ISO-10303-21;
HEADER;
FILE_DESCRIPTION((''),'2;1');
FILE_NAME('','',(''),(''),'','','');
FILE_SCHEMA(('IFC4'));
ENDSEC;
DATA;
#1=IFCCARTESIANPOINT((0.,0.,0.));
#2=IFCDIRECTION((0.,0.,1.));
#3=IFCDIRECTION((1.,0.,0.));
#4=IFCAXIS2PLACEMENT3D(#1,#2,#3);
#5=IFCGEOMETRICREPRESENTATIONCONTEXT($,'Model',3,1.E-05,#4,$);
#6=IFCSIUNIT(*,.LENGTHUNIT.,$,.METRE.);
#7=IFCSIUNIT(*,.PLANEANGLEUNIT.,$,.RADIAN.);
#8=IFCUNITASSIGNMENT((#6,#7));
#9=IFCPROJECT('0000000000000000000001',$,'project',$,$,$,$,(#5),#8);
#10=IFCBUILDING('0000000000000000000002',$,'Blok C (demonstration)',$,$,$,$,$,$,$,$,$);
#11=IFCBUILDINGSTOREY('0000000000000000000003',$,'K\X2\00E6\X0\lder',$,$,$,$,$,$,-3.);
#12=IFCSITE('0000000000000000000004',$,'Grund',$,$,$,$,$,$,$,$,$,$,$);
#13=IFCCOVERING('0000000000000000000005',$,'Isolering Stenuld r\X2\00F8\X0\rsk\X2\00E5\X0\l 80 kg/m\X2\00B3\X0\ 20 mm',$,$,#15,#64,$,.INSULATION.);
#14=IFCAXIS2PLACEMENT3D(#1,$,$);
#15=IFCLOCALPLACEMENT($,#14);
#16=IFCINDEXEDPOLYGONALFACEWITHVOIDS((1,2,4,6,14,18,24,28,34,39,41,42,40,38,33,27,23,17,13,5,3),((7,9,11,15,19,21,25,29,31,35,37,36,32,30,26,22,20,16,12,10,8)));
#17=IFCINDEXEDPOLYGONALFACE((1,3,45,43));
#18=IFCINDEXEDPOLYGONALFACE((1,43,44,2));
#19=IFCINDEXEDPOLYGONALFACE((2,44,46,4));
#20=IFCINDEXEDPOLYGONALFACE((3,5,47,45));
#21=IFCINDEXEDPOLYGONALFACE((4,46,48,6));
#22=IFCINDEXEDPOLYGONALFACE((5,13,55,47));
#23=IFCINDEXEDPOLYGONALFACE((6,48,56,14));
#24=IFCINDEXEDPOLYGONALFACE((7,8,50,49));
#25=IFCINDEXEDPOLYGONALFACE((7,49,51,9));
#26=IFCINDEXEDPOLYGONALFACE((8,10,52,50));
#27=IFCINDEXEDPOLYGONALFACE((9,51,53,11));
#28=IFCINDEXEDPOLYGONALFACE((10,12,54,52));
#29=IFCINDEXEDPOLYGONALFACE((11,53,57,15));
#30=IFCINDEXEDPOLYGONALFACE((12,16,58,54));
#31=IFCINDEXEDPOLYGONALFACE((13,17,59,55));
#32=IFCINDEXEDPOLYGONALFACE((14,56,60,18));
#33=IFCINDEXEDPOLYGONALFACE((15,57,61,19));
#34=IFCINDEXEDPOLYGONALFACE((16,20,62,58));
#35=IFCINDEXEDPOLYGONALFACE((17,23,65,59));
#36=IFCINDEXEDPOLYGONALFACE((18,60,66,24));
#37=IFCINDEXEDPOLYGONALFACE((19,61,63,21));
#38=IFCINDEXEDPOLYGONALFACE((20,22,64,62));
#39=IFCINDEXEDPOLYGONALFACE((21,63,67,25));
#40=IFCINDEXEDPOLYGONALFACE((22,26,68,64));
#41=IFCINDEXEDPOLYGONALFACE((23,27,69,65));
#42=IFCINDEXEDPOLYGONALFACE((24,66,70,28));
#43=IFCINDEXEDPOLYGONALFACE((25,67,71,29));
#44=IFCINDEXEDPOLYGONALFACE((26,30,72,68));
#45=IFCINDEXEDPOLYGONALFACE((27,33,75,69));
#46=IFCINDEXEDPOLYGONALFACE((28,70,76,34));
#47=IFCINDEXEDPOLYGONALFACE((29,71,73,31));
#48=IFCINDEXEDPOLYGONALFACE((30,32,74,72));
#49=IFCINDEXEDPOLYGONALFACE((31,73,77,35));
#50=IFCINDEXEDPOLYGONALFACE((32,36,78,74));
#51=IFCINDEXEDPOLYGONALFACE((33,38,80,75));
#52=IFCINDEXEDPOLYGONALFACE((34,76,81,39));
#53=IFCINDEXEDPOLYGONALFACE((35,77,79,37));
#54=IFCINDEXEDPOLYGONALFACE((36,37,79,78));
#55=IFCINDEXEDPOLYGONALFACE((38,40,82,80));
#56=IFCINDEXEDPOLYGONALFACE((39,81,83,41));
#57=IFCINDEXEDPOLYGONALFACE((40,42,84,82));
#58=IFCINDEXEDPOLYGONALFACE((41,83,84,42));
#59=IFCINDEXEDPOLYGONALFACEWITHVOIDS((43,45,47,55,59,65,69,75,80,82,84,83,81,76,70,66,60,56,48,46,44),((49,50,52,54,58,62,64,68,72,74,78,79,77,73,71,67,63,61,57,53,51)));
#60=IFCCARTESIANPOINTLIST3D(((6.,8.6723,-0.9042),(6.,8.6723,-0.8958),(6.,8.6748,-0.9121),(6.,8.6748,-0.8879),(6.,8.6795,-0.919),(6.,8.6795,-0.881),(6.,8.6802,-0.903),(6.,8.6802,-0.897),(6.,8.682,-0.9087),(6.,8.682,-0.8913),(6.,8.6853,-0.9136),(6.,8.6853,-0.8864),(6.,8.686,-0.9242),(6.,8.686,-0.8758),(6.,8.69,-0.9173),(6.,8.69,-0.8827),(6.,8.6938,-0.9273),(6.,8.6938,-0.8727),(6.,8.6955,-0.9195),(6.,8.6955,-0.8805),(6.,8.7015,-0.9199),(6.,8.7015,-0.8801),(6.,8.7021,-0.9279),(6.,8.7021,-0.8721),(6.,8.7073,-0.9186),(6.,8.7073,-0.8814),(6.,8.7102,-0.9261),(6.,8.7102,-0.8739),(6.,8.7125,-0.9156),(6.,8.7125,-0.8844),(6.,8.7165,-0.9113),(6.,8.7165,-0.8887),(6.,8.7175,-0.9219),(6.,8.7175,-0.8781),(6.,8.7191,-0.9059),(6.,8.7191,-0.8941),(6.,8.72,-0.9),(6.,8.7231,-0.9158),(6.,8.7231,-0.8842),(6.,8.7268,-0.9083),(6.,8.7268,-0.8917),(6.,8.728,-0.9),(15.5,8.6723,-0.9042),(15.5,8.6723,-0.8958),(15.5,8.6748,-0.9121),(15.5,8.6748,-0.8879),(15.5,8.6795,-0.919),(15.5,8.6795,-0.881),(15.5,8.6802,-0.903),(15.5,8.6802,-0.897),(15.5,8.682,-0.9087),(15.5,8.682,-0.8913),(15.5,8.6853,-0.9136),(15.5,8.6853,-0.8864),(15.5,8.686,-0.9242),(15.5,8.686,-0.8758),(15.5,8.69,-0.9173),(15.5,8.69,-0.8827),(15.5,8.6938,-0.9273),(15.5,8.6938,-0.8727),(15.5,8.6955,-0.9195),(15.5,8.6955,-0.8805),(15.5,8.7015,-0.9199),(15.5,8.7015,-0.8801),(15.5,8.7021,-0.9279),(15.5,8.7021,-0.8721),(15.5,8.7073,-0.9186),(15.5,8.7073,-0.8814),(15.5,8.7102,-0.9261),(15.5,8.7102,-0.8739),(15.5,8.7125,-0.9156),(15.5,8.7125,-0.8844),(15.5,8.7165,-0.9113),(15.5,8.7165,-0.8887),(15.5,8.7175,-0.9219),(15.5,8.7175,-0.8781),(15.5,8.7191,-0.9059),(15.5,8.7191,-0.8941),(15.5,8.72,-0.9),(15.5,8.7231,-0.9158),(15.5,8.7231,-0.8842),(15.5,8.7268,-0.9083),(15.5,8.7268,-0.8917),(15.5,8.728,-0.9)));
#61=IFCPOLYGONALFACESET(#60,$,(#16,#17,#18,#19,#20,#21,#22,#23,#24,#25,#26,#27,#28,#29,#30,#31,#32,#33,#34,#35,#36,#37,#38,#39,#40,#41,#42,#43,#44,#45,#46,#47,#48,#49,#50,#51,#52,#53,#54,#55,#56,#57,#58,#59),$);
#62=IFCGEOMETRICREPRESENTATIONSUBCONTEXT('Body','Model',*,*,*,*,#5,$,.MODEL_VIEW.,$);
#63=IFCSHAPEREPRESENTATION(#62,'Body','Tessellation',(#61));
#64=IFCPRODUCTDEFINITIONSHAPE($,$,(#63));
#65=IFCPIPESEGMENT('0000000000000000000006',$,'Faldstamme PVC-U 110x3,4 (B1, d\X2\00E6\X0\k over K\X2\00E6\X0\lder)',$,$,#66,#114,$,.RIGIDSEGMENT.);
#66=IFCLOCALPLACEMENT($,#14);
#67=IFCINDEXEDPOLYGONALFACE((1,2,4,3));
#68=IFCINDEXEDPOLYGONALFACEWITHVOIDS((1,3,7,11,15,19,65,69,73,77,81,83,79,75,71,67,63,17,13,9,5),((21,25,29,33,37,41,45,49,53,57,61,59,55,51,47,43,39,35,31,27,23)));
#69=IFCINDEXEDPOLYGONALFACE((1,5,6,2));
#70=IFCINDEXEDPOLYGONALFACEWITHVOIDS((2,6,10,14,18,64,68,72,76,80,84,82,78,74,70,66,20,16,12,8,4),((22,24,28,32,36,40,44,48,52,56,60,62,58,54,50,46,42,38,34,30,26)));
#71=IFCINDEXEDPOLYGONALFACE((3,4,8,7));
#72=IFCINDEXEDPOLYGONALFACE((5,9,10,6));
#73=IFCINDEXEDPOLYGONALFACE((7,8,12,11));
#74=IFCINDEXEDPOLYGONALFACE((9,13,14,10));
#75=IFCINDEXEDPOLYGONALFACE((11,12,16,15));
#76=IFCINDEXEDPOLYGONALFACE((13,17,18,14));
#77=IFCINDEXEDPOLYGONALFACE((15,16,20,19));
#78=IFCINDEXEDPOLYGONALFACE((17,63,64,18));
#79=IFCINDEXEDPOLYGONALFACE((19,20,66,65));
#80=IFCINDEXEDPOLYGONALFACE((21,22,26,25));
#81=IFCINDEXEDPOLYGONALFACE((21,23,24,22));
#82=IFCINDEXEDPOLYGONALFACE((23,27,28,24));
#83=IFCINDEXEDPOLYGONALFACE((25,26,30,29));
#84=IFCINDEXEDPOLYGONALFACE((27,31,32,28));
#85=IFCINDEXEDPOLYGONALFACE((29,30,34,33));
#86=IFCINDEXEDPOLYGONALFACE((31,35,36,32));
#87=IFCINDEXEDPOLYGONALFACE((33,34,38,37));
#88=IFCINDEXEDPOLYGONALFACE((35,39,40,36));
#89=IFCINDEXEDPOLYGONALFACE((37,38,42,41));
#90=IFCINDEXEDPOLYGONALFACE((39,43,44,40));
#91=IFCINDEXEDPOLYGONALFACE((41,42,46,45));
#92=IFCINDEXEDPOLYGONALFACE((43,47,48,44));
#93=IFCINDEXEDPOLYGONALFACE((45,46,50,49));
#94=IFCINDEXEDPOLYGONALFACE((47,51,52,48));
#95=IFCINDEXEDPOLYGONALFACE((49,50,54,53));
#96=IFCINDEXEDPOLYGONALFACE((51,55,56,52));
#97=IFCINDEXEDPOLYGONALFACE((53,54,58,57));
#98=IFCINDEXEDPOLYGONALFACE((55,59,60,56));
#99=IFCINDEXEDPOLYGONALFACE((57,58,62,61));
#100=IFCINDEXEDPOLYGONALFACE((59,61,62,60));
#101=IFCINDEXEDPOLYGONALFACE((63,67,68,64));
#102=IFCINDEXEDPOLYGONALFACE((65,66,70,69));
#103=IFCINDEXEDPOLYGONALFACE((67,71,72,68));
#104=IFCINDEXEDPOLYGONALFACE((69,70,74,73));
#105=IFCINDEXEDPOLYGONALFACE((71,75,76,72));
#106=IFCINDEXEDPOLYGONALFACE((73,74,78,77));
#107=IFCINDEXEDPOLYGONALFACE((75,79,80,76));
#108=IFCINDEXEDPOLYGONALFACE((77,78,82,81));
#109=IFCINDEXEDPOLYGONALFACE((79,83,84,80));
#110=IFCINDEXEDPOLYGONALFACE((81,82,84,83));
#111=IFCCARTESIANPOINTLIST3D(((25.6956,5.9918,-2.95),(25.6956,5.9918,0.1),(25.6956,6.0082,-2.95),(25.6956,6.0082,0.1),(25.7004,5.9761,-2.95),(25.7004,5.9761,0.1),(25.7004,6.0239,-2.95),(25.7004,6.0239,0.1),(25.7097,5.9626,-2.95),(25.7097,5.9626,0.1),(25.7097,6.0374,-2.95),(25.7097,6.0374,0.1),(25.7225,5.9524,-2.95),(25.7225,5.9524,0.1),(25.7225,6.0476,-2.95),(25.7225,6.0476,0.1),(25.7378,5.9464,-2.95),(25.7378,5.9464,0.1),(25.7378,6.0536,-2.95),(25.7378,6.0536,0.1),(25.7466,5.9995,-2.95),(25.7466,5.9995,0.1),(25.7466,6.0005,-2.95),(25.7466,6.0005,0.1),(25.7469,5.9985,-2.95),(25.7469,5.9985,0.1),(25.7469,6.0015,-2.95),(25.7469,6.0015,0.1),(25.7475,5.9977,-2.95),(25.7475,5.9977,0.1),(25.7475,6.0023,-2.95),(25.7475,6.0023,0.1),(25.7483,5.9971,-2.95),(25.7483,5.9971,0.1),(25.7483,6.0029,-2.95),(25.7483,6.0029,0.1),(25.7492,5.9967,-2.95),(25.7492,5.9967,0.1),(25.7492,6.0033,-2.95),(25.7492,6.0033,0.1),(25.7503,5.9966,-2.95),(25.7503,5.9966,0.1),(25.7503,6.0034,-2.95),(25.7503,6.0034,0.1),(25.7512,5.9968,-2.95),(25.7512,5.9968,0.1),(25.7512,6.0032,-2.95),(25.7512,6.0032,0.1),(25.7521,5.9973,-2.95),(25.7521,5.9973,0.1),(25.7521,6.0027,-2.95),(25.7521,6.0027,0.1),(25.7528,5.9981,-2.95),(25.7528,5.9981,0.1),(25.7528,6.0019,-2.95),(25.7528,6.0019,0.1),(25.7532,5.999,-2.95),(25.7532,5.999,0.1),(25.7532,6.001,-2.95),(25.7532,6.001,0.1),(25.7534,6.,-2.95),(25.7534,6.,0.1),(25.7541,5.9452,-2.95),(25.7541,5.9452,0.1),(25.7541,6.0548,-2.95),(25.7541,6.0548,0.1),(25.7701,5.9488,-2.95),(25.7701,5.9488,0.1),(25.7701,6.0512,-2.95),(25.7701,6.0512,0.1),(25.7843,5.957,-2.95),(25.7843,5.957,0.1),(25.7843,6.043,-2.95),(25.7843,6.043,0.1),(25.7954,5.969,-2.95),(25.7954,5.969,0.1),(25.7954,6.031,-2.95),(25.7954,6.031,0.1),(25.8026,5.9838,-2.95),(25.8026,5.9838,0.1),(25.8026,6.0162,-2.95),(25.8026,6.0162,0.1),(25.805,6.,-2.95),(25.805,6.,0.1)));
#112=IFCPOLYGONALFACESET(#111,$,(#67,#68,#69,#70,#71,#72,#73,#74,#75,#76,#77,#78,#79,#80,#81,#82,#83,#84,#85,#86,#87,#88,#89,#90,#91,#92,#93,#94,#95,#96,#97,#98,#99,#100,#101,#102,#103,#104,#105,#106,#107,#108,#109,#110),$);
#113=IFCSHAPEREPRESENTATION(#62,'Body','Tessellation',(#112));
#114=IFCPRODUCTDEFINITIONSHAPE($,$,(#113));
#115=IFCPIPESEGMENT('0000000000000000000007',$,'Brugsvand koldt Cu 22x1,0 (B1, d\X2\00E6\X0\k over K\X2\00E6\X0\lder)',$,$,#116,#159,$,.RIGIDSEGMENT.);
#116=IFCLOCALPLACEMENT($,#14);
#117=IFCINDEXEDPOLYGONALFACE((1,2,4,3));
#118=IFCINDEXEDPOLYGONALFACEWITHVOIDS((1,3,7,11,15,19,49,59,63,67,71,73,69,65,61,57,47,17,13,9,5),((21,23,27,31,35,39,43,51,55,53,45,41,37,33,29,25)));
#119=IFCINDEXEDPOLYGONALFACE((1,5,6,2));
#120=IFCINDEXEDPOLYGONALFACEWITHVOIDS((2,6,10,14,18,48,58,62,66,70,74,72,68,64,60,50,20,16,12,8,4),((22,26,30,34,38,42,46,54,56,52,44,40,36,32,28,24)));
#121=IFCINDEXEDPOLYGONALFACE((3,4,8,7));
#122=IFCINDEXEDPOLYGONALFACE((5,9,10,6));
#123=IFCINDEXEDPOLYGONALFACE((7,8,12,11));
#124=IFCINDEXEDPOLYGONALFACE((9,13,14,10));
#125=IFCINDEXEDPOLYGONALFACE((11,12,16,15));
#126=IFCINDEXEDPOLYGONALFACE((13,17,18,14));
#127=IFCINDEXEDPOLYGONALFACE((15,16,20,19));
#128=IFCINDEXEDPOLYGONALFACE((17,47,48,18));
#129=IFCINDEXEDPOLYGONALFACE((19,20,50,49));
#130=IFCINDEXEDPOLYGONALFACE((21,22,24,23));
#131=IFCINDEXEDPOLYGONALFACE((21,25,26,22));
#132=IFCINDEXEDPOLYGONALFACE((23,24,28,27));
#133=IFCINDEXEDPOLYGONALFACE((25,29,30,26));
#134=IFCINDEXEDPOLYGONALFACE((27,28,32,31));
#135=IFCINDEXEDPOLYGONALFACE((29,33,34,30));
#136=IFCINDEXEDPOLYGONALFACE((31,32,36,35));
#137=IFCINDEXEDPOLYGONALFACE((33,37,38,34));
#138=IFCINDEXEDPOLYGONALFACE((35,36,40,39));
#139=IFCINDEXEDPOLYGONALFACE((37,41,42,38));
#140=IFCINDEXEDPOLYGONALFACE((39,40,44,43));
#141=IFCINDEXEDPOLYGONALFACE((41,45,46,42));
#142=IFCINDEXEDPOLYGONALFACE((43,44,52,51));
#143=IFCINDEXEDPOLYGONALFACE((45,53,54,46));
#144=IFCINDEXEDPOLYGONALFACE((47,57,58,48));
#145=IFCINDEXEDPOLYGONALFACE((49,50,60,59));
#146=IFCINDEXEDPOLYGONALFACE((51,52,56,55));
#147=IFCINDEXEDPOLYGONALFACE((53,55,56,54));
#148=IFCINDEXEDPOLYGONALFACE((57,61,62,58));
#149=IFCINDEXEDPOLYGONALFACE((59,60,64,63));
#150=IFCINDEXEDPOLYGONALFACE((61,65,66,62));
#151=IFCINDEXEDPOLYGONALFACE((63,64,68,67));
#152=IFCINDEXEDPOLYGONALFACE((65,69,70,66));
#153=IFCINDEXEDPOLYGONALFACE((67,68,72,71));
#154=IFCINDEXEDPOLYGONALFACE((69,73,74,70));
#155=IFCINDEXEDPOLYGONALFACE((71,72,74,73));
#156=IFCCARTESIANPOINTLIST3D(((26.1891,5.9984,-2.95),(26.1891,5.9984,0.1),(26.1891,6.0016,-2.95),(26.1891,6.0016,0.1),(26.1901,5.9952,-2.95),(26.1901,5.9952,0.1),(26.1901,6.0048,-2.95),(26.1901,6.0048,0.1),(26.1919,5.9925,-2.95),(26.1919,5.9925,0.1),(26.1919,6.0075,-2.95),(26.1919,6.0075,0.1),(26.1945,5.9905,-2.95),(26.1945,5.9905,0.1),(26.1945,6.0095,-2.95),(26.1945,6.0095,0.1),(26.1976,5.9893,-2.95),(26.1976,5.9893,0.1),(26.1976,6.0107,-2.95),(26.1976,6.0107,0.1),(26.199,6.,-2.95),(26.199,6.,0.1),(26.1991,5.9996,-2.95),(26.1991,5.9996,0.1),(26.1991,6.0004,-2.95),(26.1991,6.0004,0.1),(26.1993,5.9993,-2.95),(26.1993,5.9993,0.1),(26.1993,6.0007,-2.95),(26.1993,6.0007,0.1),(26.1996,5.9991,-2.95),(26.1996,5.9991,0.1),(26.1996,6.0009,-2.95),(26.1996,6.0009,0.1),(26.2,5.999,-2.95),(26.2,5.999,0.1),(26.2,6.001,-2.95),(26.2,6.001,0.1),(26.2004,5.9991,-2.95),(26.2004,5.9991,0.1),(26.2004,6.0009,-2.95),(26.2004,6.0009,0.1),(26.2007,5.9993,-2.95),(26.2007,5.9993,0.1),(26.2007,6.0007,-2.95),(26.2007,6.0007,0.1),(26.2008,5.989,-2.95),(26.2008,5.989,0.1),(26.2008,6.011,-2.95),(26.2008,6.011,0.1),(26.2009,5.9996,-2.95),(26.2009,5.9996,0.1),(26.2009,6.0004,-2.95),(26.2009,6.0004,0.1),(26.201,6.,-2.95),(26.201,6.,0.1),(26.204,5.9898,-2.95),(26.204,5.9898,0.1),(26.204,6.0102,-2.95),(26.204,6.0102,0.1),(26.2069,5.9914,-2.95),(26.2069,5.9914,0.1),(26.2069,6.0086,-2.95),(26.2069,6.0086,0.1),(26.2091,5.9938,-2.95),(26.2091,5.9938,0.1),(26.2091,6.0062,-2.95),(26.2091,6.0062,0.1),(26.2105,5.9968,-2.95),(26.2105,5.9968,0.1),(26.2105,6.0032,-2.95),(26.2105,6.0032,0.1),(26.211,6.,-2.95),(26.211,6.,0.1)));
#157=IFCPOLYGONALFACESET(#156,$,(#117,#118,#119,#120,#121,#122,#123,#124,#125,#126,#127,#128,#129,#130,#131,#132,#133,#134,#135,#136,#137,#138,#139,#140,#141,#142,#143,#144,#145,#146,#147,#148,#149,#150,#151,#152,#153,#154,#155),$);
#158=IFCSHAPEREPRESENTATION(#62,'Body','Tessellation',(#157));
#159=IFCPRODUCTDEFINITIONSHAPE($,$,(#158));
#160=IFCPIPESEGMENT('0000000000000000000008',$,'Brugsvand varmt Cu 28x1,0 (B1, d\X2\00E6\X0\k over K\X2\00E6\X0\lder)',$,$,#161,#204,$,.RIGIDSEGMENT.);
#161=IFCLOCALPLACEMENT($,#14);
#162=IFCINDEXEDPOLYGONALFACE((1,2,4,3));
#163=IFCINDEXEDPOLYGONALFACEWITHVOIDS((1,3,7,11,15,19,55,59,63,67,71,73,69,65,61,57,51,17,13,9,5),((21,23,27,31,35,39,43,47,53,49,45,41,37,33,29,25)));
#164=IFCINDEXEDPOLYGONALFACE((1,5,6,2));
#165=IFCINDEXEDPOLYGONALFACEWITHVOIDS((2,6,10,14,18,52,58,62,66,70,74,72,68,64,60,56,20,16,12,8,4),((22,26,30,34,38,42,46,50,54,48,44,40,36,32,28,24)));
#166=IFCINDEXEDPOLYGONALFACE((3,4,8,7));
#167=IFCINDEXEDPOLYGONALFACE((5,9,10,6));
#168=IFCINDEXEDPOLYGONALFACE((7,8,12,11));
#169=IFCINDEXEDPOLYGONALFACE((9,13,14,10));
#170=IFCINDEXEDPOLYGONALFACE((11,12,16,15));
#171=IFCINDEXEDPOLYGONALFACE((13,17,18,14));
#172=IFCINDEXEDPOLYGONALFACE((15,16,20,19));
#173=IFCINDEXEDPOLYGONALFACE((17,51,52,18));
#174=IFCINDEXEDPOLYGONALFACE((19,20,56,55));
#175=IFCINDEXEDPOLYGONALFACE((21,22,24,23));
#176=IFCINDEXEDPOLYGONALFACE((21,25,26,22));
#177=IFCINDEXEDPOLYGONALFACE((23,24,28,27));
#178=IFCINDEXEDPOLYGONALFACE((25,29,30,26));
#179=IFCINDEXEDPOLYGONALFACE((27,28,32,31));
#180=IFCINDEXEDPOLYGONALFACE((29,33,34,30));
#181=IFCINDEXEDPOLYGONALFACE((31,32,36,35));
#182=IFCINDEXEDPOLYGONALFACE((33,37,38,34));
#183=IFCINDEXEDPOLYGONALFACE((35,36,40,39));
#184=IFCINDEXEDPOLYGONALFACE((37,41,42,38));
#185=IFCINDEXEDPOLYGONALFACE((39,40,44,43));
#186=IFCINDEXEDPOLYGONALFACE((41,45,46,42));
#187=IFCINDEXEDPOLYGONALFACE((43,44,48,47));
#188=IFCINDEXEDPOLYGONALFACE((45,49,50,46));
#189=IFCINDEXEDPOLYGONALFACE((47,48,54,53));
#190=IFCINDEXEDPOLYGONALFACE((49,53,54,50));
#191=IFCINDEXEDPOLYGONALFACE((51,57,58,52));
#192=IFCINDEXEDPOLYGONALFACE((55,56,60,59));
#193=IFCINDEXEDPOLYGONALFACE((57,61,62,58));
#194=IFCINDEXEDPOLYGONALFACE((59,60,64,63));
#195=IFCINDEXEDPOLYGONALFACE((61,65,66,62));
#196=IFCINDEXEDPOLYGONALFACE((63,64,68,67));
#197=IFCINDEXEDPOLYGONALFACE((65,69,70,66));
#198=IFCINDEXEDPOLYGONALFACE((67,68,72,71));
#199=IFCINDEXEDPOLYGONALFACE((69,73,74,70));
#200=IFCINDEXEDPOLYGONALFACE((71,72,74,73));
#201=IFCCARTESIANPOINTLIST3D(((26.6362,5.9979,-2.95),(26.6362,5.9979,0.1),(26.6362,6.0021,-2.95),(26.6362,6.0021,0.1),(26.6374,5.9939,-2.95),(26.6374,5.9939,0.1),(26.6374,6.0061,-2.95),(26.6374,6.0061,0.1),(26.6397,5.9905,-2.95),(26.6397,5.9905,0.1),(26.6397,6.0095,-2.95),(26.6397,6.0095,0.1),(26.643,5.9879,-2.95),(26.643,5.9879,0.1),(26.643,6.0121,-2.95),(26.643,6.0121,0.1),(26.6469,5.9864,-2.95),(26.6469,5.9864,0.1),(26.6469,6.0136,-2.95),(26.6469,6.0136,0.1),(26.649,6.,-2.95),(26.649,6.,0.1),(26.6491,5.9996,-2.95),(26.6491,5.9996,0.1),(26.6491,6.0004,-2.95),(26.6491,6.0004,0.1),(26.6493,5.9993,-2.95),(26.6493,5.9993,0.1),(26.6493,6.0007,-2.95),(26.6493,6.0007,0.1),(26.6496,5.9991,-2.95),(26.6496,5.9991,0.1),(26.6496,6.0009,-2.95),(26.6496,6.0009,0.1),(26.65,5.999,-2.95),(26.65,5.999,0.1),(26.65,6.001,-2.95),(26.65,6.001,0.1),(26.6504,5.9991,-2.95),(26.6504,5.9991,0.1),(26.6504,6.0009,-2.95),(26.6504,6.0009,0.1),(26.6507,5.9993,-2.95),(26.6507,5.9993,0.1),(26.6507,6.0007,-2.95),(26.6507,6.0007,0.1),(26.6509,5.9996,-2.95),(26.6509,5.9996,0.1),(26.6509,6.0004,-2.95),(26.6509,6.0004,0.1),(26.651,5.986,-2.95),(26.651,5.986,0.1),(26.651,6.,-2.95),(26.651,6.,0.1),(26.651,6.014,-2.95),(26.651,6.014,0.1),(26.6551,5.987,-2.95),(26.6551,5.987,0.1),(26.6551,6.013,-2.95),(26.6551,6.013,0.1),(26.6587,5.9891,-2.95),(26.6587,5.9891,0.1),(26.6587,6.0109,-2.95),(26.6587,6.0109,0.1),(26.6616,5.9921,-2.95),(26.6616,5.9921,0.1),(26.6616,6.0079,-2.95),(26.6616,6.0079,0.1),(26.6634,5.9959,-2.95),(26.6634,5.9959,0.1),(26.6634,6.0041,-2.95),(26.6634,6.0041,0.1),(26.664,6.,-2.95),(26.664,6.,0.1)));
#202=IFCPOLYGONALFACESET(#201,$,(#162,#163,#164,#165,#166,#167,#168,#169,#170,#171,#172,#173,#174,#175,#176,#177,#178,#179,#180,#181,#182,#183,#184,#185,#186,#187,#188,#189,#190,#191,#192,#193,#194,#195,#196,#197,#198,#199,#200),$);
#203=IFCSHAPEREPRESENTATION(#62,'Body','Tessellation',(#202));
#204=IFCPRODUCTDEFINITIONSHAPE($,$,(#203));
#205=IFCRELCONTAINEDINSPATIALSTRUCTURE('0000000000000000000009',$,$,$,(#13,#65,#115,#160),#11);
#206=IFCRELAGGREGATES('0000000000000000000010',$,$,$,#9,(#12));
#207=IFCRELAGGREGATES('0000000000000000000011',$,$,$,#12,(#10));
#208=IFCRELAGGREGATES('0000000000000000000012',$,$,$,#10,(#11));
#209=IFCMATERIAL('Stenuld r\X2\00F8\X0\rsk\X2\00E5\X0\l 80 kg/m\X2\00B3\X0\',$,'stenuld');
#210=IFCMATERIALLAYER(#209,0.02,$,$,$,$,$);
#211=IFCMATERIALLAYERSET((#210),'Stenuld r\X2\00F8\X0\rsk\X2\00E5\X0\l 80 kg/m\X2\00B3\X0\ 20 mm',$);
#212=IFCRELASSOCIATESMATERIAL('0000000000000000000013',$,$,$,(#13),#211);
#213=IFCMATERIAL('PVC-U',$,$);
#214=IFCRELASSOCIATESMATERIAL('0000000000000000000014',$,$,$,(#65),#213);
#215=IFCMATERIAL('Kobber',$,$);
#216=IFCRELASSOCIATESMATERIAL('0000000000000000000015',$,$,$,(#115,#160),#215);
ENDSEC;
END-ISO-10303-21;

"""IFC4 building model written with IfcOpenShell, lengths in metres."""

from ifc_helpers import new_model, si_unit, frame, origin_with_axes, place, context, subcontext, project, spatial, hollow_circle, extrude, material, layer, layer_set, element, save


model = new_model("IFC4")

# Units and contexts
model_context = context("Model", 3, precision=1e-05, world=origin_with_axes())
body_context = subcontext(model_context, "Body", "Model", "MODEL_VIEW")
ifc_project = project(units=[si_unit("LENGTHUNIT", "METRE"), si_unit("PLANEANGLEUNIT", "RADIAN")], contexts=[model_context])

# Site, building, storey
site = spatial("IfcSite", under=ifc_project, Name="Grund")
building = spatial("IfcBuilding", under=site, Name="Blok C (demonstration)")
storey = spatial("IfcBuildingStorey", under=building, Name="Kælder", Elevation=-3.0)

# Covering
ifc_material_1 = material(Name="Stenuld rørskål 80 kg/m³", Category="stenuld")
ifc_layer_1 = layer(ifc_material_1, 0.02)
ifc_layer_set_1 = layer_set([ifc_layer_1], Name="Stenuld rørskål 80 kg/m³ 20 mm")
covering_1_placement = place(None, origin_with_axes())
element("IfcCovering", 1, at=covering_1_placement, inside=storey, material=ifc_layer_set_1, Name="Isolering Stenuld rørskål 80 kg/m³ 20 mm", PredefinedType="INSULATION", context=body_context, shape_type="SweptSolid", body=[
    extrude(hollow_circle(Radius=0.028, WallThickness=0.008), frame((6.0, 8.7, -0.9), z_axis=(1.0, 0.0, 0.0), x_axis=(0.0, 1.0, 0.0)), (0.0, 0.0, 1.0), 9.5),
])

# Pipe segments
ifc_material_2 = material(Name="PVC-U")
pipe_segment_1_placement = place(None, origin_with_axes())
element("IfcPipeSegment", 2, at=pipe_segment_1_placement, inside=storey, material=ifc_material_2, Name="Faldstamme PVC-U 110x3,4 (B1, dæk over Kælder)", PredefinedType="RIGIDSEGMENT", context=body_context, shape_type="SweptSolid", body=[
    extrude(hollow_circle(Radius=0.055, WallThickness=0.0516), frame((25.75, 6.0, -2.95), z_axis=(0.0, 0.0, 1.0), x_axis=(1.0, 0.0, 0.0)), (0.0, 0.0, 1.0), 3.05),
])
ifc_material_3 = material(Name="Kobber")
pipe_segment_2_placement = place(None, origin_with_axes())
element("IfcPipeSegment", 3, at=pipe_segment_2_placement, inside=storey, material=ifc_material_3, Name="Brugsvand koldt Cu 22x1,0 (B1, dæk over Kælder)", PredefinedType="RIGIDSEGMENT", context=body_context, shape_type="SweptSolid", body=[
    extrude(hollow_circle(Radius=0.011, WallThickness=0.01), frame((26.2, 6.0, -2.95), z_axis=(0.0, 0.0, 1.0), x_axis=(1.0, 0.0, 0.0)), (0.0, 0.0, 1.0), 3.05),
])
pipe_segment_3_placement = place(None, origin_with_axes())
element("IfcPipeSegment", 4, at=pipe_segment_3_placement, inside=storey, material=ifc_material_3, Name="Brugsvand varmt Cu 28x1,0 (B1, dæk over Kælder)", PredefinedType="RIGIDSEGMENT", context=body_context, shape_type="SweptSolid", body=[
    extrude(hollow_circle(Radius=0.014, WallThickness=0.013), frame((26.65, 6.0, -2.95), z_axis=(0.0, 0.0, 1.0), x_axis=(1.0, 0.0, 0.0)), (0.0, 0.0, 1.0), 3.05),
])

save(model, "model.ifc")
